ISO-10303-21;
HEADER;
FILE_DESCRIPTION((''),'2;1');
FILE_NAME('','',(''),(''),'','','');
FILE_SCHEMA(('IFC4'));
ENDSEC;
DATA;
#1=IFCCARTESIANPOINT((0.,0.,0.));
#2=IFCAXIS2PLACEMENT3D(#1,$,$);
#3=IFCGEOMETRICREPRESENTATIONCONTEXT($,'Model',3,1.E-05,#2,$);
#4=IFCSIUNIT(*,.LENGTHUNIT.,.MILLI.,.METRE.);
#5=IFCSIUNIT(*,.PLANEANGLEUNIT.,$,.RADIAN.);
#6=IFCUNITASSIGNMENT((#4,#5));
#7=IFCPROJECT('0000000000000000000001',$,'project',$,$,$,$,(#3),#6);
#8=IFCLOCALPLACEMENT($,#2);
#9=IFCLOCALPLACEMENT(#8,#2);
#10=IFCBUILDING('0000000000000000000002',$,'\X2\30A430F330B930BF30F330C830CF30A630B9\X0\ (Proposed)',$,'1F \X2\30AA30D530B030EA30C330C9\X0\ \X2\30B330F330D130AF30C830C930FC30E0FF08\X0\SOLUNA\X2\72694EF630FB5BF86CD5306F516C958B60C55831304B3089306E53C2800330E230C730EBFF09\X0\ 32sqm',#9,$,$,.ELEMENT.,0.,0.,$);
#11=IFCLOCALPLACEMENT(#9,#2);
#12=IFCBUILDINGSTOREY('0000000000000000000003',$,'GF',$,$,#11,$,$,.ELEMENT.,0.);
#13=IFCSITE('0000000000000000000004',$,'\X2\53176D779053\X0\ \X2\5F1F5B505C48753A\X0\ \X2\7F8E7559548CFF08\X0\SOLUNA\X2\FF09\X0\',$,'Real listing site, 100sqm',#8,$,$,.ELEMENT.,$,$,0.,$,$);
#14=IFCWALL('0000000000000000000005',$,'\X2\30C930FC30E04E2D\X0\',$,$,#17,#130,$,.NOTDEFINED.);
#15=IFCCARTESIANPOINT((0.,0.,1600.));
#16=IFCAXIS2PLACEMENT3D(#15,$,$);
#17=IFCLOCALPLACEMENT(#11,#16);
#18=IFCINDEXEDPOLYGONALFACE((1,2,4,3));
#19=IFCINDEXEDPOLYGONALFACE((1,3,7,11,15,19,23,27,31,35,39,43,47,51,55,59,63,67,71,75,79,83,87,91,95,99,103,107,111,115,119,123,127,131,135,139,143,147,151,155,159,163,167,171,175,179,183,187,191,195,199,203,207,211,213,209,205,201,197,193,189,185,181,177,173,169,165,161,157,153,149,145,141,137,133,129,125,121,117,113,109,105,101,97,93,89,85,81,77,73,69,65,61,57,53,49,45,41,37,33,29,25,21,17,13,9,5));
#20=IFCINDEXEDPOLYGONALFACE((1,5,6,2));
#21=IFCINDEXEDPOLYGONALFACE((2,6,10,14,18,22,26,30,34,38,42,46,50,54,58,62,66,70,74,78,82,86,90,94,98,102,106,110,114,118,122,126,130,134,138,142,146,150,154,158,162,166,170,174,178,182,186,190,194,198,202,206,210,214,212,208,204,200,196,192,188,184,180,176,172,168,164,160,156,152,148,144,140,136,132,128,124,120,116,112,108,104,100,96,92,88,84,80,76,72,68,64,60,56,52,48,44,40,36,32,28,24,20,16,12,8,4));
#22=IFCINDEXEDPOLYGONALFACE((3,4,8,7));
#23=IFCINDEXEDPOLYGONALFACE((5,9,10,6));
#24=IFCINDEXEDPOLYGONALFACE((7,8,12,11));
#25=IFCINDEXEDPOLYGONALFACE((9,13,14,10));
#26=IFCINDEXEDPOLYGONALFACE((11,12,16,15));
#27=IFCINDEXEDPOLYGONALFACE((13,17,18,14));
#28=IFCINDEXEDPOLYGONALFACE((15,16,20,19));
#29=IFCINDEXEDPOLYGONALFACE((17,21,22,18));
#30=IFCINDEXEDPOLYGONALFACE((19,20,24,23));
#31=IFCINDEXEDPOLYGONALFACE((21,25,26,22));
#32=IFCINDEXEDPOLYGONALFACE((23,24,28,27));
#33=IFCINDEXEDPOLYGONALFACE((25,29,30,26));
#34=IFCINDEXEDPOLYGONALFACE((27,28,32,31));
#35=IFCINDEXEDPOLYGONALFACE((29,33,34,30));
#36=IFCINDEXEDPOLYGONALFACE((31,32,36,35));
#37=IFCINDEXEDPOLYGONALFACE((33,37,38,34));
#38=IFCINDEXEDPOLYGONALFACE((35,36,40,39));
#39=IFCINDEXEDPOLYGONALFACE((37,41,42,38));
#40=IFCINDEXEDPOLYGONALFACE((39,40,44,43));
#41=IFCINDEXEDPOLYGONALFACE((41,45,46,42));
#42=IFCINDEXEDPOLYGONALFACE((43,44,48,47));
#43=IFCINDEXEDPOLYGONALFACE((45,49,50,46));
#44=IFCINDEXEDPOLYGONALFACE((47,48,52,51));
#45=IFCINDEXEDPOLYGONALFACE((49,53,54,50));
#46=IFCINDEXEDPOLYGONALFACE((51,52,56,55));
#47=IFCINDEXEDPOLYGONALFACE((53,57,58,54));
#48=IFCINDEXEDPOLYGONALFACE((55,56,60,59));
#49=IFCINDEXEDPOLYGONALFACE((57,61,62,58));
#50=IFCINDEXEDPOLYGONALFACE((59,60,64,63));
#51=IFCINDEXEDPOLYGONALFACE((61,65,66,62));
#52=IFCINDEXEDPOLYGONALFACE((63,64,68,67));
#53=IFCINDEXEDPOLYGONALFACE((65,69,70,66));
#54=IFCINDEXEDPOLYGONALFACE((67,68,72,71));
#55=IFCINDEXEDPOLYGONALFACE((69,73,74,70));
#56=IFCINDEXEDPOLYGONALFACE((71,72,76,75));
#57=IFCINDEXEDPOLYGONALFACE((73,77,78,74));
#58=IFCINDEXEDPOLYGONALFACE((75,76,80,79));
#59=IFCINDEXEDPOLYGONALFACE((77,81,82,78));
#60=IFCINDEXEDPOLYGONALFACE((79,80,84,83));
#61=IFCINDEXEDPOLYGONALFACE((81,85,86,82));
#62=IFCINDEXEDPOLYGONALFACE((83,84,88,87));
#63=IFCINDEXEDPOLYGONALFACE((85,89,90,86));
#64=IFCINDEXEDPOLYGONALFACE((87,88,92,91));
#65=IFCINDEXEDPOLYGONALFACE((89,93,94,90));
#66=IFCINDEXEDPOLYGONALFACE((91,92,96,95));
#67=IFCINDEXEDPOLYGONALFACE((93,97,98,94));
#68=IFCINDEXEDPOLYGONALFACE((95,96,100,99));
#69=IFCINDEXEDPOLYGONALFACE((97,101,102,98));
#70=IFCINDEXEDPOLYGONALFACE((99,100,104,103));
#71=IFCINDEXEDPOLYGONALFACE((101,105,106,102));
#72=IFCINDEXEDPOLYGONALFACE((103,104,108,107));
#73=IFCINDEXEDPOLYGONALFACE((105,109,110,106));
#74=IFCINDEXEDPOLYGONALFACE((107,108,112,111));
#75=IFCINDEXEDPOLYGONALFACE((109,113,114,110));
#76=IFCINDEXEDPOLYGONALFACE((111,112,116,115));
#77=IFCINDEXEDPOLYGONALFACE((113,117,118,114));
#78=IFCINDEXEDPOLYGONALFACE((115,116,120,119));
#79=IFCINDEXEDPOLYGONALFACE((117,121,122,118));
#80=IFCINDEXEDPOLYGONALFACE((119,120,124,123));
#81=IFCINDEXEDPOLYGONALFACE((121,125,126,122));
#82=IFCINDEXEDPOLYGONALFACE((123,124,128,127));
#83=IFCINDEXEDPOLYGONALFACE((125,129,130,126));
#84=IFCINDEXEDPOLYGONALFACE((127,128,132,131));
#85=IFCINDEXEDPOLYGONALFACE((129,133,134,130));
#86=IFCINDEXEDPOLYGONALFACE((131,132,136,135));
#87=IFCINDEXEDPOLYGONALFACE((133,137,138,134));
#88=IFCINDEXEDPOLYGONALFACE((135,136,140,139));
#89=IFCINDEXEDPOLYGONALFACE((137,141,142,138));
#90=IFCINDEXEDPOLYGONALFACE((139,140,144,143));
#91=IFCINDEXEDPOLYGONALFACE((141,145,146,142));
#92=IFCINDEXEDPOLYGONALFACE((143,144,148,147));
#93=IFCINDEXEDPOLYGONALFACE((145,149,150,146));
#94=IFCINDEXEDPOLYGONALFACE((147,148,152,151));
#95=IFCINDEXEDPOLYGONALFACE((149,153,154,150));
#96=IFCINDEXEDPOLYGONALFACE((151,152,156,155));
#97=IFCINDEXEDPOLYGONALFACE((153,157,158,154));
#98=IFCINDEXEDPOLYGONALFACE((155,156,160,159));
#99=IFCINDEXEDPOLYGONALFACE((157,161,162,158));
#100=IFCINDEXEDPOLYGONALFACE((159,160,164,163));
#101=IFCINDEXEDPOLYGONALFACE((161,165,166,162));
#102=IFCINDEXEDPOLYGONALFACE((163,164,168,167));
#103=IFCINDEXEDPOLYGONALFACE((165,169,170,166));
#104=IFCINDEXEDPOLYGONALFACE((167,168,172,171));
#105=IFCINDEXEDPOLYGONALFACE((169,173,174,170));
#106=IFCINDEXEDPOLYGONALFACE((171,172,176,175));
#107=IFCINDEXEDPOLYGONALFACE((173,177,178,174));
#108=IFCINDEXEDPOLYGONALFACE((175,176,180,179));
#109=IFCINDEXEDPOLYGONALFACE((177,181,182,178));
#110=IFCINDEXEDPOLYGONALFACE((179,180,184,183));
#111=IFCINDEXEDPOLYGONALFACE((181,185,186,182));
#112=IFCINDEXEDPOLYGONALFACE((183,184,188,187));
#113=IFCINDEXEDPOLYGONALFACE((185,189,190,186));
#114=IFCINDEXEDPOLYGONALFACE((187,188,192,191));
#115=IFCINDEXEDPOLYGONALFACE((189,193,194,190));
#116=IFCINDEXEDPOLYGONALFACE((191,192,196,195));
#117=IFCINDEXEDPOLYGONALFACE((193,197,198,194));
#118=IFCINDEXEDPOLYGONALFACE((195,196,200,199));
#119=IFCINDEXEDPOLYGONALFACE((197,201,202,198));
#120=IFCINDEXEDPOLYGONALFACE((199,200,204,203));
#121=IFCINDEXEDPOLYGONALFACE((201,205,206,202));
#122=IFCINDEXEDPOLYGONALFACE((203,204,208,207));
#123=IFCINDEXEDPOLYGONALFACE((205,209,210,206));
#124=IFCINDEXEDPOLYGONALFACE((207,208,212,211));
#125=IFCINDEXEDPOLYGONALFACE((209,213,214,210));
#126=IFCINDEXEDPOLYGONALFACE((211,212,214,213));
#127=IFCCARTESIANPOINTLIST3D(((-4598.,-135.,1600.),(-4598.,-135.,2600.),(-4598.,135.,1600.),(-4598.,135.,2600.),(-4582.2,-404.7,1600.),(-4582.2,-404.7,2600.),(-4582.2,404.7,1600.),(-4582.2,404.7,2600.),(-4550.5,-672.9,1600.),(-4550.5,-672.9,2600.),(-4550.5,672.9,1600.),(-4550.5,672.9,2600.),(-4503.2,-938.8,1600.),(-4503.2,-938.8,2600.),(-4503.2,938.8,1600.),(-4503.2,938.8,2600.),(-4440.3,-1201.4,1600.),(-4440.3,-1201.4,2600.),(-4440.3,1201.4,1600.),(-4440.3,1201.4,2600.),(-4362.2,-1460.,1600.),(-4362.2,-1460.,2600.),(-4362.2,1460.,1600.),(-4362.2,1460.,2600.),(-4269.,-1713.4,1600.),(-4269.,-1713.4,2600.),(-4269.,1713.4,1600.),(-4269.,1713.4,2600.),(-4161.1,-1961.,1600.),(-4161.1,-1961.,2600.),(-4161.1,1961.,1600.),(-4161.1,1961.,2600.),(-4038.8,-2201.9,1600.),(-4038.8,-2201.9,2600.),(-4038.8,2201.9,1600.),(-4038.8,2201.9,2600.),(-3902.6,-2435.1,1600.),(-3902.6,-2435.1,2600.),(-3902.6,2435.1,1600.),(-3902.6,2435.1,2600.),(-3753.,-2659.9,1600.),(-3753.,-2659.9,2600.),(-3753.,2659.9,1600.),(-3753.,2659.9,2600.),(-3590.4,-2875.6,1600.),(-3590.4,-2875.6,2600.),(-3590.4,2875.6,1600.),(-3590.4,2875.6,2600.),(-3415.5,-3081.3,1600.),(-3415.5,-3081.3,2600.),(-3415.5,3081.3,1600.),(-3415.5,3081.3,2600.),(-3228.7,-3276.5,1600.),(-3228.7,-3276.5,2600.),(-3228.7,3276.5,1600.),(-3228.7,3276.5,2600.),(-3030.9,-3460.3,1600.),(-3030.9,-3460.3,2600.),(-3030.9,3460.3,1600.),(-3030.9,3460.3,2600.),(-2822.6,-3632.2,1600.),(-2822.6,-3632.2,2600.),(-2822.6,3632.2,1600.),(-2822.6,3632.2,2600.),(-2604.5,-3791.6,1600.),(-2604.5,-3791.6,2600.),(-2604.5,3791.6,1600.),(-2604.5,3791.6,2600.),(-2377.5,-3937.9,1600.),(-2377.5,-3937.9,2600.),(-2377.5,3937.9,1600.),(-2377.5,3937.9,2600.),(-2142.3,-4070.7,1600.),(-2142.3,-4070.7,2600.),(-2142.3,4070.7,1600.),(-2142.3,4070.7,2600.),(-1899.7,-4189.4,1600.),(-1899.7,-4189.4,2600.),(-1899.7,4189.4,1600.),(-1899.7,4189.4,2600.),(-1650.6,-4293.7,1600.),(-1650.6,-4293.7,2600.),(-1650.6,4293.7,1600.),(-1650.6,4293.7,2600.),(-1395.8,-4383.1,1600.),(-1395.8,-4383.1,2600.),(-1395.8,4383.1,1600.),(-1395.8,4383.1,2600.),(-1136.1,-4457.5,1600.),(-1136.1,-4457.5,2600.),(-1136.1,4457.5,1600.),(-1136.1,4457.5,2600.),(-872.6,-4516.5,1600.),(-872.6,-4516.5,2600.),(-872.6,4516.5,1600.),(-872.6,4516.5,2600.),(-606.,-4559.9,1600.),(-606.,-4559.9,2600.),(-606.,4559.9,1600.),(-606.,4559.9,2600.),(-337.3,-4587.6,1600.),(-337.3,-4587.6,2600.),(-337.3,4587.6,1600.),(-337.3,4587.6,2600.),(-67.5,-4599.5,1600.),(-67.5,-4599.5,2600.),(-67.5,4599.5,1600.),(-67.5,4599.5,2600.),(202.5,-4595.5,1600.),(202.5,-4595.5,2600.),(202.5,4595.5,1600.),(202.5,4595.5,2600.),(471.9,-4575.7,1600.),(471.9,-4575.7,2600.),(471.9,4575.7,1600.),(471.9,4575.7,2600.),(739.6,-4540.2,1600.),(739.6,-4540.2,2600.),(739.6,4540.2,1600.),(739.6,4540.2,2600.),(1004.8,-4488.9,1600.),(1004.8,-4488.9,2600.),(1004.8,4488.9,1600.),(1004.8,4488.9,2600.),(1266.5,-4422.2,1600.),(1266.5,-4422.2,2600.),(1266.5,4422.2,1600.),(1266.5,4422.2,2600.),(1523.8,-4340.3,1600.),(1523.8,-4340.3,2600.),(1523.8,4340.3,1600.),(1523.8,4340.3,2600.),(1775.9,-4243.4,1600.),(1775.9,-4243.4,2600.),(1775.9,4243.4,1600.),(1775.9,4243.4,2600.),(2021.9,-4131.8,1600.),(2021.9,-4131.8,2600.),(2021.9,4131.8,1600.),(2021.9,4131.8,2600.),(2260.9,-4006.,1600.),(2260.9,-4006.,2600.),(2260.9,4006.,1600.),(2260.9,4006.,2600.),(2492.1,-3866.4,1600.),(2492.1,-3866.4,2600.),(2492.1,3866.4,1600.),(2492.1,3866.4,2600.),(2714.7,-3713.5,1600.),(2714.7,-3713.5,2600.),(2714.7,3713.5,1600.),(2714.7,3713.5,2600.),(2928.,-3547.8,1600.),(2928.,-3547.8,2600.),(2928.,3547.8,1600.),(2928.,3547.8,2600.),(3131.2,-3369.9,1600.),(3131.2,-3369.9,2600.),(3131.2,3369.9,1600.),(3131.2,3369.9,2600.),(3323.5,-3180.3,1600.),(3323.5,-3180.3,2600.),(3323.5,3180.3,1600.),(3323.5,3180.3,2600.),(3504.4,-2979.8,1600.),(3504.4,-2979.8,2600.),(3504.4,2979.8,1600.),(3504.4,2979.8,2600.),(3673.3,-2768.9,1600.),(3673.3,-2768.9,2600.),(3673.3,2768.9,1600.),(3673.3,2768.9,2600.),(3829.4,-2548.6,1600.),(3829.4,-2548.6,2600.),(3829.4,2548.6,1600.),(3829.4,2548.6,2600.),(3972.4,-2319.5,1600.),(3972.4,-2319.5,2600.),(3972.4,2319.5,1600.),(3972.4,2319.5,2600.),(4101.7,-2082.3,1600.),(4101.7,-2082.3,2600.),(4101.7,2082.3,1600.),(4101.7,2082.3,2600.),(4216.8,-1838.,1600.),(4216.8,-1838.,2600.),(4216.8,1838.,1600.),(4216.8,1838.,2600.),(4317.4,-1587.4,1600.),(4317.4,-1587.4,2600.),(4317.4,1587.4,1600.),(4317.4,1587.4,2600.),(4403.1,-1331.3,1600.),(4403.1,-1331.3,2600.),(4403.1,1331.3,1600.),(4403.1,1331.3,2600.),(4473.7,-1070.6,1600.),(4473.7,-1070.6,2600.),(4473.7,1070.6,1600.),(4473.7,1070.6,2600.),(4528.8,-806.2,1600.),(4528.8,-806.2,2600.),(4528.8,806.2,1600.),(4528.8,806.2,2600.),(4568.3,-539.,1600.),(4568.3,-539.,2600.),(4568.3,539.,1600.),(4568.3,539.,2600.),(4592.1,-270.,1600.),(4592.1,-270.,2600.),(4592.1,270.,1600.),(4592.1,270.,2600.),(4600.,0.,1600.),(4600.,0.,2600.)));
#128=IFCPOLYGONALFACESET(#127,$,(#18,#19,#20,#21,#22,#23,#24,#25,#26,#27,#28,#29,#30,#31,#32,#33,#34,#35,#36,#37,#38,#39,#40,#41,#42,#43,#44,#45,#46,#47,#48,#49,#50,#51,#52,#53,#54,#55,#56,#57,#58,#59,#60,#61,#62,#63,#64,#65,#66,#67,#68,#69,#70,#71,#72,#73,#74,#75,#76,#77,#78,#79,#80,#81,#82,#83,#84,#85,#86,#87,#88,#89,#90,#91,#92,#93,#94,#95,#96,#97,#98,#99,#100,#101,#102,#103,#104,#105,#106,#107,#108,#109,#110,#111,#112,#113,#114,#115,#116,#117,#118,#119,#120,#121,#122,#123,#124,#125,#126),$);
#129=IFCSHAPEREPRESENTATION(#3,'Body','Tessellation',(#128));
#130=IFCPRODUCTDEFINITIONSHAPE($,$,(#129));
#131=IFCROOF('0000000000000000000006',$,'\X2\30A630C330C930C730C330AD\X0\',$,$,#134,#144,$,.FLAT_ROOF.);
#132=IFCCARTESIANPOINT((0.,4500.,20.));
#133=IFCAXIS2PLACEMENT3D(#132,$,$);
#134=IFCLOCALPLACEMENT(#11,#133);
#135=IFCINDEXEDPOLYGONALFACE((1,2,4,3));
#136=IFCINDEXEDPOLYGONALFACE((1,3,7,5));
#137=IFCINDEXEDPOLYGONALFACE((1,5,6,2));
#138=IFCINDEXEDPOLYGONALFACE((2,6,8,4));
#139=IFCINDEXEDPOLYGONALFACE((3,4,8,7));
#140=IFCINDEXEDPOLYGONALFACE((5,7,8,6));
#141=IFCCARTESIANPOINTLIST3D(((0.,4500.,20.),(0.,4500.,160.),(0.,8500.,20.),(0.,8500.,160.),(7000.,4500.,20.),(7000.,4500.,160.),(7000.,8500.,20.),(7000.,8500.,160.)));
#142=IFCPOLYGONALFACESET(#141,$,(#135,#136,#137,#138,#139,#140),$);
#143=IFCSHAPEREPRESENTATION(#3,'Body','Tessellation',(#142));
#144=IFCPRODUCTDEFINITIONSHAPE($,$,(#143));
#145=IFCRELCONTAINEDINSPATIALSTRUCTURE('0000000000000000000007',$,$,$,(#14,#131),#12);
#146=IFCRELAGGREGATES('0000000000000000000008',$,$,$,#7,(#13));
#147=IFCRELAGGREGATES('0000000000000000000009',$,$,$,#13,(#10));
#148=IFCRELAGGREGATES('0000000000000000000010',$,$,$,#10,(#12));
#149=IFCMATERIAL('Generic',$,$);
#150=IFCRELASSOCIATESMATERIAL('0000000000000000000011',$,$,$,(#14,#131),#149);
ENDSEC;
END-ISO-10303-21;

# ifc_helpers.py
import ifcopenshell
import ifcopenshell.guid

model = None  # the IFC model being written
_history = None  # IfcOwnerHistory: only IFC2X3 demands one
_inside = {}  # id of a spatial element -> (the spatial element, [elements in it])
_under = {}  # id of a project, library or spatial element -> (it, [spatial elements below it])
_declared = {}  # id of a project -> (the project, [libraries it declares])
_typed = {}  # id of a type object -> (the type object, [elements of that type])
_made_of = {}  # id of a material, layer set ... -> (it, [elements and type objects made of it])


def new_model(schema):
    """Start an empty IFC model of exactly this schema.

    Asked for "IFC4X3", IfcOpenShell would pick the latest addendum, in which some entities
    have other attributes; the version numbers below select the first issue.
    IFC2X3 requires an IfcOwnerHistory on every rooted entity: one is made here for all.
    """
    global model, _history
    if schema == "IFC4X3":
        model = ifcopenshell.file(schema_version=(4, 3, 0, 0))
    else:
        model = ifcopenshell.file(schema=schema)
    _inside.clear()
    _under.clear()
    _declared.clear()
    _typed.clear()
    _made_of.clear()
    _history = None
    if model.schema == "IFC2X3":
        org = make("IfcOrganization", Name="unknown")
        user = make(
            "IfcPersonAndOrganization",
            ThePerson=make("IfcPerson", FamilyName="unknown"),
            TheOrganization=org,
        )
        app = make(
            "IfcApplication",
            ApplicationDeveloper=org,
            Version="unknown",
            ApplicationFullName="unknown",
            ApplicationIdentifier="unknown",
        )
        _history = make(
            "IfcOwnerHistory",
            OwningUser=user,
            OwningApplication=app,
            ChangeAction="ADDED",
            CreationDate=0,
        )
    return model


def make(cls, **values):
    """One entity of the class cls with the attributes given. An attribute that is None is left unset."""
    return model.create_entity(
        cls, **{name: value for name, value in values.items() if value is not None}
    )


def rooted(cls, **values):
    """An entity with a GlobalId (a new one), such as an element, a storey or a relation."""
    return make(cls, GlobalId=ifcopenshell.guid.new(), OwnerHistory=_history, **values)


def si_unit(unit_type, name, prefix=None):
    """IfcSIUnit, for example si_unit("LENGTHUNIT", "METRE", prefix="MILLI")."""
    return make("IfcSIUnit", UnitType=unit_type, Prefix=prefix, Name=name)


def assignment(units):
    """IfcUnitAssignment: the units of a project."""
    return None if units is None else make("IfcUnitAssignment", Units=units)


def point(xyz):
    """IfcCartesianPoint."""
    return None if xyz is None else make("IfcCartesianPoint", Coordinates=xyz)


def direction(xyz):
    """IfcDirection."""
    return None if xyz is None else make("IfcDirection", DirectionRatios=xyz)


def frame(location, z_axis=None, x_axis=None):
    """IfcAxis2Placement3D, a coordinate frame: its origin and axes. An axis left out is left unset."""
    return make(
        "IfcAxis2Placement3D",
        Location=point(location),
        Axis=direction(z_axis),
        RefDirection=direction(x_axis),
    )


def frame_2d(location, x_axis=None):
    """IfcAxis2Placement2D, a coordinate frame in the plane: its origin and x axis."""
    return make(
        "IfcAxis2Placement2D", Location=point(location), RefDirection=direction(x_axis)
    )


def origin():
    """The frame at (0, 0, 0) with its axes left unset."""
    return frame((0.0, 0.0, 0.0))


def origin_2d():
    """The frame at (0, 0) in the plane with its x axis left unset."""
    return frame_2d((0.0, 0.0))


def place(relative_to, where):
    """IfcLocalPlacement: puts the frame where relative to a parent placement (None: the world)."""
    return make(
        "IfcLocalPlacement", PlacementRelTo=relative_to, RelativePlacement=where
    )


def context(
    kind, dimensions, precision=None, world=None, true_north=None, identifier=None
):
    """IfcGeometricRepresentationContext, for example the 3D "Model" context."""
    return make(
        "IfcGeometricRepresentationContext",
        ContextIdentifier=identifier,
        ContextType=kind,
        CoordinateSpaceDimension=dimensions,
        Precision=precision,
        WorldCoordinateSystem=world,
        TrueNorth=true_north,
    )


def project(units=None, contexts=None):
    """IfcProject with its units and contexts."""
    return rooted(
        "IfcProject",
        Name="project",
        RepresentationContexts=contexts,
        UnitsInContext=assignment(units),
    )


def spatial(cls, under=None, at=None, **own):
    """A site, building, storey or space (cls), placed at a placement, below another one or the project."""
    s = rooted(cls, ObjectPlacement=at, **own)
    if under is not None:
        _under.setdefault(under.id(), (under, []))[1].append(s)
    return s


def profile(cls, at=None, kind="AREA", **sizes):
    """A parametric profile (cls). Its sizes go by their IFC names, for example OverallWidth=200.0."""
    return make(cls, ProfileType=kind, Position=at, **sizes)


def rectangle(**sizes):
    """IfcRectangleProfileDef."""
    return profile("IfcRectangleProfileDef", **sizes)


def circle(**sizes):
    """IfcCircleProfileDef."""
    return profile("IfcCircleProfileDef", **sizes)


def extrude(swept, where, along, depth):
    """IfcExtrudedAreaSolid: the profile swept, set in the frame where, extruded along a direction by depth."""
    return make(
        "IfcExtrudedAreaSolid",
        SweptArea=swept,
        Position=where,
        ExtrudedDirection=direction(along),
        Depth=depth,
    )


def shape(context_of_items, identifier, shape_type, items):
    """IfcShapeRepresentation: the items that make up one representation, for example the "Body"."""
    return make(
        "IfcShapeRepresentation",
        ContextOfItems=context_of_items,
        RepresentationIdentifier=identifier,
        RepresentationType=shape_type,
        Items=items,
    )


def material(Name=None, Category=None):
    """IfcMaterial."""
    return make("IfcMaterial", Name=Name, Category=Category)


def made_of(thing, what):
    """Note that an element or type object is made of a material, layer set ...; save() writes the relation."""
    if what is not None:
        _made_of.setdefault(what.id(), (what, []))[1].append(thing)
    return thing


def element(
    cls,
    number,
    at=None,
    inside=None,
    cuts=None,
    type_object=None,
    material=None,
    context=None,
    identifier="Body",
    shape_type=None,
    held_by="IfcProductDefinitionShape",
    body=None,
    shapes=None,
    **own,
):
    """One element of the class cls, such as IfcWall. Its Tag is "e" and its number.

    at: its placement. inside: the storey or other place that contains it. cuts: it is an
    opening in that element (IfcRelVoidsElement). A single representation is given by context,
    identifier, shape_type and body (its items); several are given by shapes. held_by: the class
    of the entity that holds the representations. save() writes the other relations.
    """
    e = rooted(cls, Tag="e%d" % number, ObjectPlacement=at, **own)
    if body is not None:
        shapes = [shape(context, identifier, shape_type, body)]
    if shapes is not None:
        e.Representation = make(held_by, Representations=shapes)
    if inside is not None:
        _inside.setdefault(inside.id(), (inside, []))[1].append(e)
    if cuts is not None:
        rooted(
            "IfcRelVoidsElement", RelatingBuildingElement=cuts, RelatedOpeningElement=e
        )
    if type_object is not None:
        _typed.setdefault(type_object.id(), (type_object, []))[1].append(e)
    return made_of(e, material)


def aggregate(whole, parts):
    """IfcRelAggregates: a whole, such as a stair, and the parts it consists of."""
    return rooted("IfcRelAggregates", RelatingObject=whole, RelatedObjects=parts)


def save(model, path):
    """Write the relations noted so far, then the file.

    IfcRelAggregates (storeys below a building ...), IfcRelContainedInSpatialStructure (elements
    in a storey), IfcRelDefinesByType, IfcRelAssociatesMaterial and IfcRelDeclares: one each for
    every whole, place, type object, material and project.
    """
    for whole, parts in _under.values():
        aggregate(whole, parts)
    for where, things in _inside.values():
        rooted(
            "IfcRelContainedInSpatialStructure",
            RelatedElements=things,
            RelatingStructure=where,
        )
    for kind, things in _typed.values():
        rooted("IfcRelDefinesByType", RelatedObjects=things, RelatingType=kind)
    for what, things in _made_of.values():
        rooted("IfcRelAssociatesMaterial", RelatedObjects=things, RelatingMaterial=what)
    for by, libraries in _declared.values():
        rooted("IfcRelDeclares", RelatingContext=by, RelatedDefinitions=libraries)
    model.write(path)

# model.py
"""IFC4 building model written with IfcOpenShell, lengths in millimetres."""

from ifc_helpers import new_model, si_unit, frame, frame_2d, origin, origin_2d, place, context, project, spatial, rectangle, circle, extrude, material, element, save


model = new_model("IFC4")

# Units and contexts
model_context = context("Model", 3, precision=1e-05, world=origin())
ifc_project = project(units=[si_unit("LENGTHUNIT", "METRE", prefix="MILLI"), si_unit("PLANEANGLEUNIT", "RADIAN")], contexts=[model_context])

# Site, building, storey
site_placement = place(None, origin())
site = spatial("IfcSite", under=ifc_project, at=site_placement, Name="北海道 弟子屈町 美留和（SOLUNA）", ObjectType="Real listing site, 100sqm", CompositionType="ELEMENT", RefElevation=0.0)
building_placement = place(site_placement, origin())
building = spatial("IfcBuilding", under=site, at=building_placement, Name="インスタントハウス (Proposed)", ObjectType="1F オフグリッド コンパクトドーム（SOLUNA物件・寸法は公開情報からの参考モデル） 32sqm", CompositionType="ELEMENT", ElevationOfRefHeight=0.0, ElevationOfTerrain=0.0)
storey_placement = place(building_placement, origin())
storey = spatial("IfcBuildingStorey", under=building, at=storey_placement, Name="GF", CompositionType="ELEMENT", Elevation=0.0)

# Shared definitions
ifc_material_1 = material(Name="Generic")

# Wall
wall_1_placement = place(storey_placement, frame((0.0, 0.0, 1600.0)))
element("IfcWall", 1, at=wall_1_placement, inside=storey, material=ifc_material_1, Name="ドーム中", PredefinedType="NOTDEFINED", context=model_context, shape_type="SweptSolid", body=[
    extrude(circle(Radius=4600.0, at=origin_2d()), frame((0.0, 0.0, 1600.0)), (0.0, 0.0, 1.0), 1000.0),
])

# Roof
roof_1_placement = place(storey_placement, frame((0.0, 4500.0, 20.0)))
element("IfcRoof", 2, at=roof_1_placement, inside=storey, material=ifc_material_1, Name="ウッドデッキ", PredefinedType="FLAT_ROOF", context=model_context, shape_type="SweptSolid", body=[
    extrude(rectangle(XDim=7000.0, YDim=4000.0, at=frame_2d((3500.0, 2000.0))), frame((0.0, 4500.0, 20.0)), (0.0, 0.0, 1.0), 140.0),
])

save(model, "model.ifc")
